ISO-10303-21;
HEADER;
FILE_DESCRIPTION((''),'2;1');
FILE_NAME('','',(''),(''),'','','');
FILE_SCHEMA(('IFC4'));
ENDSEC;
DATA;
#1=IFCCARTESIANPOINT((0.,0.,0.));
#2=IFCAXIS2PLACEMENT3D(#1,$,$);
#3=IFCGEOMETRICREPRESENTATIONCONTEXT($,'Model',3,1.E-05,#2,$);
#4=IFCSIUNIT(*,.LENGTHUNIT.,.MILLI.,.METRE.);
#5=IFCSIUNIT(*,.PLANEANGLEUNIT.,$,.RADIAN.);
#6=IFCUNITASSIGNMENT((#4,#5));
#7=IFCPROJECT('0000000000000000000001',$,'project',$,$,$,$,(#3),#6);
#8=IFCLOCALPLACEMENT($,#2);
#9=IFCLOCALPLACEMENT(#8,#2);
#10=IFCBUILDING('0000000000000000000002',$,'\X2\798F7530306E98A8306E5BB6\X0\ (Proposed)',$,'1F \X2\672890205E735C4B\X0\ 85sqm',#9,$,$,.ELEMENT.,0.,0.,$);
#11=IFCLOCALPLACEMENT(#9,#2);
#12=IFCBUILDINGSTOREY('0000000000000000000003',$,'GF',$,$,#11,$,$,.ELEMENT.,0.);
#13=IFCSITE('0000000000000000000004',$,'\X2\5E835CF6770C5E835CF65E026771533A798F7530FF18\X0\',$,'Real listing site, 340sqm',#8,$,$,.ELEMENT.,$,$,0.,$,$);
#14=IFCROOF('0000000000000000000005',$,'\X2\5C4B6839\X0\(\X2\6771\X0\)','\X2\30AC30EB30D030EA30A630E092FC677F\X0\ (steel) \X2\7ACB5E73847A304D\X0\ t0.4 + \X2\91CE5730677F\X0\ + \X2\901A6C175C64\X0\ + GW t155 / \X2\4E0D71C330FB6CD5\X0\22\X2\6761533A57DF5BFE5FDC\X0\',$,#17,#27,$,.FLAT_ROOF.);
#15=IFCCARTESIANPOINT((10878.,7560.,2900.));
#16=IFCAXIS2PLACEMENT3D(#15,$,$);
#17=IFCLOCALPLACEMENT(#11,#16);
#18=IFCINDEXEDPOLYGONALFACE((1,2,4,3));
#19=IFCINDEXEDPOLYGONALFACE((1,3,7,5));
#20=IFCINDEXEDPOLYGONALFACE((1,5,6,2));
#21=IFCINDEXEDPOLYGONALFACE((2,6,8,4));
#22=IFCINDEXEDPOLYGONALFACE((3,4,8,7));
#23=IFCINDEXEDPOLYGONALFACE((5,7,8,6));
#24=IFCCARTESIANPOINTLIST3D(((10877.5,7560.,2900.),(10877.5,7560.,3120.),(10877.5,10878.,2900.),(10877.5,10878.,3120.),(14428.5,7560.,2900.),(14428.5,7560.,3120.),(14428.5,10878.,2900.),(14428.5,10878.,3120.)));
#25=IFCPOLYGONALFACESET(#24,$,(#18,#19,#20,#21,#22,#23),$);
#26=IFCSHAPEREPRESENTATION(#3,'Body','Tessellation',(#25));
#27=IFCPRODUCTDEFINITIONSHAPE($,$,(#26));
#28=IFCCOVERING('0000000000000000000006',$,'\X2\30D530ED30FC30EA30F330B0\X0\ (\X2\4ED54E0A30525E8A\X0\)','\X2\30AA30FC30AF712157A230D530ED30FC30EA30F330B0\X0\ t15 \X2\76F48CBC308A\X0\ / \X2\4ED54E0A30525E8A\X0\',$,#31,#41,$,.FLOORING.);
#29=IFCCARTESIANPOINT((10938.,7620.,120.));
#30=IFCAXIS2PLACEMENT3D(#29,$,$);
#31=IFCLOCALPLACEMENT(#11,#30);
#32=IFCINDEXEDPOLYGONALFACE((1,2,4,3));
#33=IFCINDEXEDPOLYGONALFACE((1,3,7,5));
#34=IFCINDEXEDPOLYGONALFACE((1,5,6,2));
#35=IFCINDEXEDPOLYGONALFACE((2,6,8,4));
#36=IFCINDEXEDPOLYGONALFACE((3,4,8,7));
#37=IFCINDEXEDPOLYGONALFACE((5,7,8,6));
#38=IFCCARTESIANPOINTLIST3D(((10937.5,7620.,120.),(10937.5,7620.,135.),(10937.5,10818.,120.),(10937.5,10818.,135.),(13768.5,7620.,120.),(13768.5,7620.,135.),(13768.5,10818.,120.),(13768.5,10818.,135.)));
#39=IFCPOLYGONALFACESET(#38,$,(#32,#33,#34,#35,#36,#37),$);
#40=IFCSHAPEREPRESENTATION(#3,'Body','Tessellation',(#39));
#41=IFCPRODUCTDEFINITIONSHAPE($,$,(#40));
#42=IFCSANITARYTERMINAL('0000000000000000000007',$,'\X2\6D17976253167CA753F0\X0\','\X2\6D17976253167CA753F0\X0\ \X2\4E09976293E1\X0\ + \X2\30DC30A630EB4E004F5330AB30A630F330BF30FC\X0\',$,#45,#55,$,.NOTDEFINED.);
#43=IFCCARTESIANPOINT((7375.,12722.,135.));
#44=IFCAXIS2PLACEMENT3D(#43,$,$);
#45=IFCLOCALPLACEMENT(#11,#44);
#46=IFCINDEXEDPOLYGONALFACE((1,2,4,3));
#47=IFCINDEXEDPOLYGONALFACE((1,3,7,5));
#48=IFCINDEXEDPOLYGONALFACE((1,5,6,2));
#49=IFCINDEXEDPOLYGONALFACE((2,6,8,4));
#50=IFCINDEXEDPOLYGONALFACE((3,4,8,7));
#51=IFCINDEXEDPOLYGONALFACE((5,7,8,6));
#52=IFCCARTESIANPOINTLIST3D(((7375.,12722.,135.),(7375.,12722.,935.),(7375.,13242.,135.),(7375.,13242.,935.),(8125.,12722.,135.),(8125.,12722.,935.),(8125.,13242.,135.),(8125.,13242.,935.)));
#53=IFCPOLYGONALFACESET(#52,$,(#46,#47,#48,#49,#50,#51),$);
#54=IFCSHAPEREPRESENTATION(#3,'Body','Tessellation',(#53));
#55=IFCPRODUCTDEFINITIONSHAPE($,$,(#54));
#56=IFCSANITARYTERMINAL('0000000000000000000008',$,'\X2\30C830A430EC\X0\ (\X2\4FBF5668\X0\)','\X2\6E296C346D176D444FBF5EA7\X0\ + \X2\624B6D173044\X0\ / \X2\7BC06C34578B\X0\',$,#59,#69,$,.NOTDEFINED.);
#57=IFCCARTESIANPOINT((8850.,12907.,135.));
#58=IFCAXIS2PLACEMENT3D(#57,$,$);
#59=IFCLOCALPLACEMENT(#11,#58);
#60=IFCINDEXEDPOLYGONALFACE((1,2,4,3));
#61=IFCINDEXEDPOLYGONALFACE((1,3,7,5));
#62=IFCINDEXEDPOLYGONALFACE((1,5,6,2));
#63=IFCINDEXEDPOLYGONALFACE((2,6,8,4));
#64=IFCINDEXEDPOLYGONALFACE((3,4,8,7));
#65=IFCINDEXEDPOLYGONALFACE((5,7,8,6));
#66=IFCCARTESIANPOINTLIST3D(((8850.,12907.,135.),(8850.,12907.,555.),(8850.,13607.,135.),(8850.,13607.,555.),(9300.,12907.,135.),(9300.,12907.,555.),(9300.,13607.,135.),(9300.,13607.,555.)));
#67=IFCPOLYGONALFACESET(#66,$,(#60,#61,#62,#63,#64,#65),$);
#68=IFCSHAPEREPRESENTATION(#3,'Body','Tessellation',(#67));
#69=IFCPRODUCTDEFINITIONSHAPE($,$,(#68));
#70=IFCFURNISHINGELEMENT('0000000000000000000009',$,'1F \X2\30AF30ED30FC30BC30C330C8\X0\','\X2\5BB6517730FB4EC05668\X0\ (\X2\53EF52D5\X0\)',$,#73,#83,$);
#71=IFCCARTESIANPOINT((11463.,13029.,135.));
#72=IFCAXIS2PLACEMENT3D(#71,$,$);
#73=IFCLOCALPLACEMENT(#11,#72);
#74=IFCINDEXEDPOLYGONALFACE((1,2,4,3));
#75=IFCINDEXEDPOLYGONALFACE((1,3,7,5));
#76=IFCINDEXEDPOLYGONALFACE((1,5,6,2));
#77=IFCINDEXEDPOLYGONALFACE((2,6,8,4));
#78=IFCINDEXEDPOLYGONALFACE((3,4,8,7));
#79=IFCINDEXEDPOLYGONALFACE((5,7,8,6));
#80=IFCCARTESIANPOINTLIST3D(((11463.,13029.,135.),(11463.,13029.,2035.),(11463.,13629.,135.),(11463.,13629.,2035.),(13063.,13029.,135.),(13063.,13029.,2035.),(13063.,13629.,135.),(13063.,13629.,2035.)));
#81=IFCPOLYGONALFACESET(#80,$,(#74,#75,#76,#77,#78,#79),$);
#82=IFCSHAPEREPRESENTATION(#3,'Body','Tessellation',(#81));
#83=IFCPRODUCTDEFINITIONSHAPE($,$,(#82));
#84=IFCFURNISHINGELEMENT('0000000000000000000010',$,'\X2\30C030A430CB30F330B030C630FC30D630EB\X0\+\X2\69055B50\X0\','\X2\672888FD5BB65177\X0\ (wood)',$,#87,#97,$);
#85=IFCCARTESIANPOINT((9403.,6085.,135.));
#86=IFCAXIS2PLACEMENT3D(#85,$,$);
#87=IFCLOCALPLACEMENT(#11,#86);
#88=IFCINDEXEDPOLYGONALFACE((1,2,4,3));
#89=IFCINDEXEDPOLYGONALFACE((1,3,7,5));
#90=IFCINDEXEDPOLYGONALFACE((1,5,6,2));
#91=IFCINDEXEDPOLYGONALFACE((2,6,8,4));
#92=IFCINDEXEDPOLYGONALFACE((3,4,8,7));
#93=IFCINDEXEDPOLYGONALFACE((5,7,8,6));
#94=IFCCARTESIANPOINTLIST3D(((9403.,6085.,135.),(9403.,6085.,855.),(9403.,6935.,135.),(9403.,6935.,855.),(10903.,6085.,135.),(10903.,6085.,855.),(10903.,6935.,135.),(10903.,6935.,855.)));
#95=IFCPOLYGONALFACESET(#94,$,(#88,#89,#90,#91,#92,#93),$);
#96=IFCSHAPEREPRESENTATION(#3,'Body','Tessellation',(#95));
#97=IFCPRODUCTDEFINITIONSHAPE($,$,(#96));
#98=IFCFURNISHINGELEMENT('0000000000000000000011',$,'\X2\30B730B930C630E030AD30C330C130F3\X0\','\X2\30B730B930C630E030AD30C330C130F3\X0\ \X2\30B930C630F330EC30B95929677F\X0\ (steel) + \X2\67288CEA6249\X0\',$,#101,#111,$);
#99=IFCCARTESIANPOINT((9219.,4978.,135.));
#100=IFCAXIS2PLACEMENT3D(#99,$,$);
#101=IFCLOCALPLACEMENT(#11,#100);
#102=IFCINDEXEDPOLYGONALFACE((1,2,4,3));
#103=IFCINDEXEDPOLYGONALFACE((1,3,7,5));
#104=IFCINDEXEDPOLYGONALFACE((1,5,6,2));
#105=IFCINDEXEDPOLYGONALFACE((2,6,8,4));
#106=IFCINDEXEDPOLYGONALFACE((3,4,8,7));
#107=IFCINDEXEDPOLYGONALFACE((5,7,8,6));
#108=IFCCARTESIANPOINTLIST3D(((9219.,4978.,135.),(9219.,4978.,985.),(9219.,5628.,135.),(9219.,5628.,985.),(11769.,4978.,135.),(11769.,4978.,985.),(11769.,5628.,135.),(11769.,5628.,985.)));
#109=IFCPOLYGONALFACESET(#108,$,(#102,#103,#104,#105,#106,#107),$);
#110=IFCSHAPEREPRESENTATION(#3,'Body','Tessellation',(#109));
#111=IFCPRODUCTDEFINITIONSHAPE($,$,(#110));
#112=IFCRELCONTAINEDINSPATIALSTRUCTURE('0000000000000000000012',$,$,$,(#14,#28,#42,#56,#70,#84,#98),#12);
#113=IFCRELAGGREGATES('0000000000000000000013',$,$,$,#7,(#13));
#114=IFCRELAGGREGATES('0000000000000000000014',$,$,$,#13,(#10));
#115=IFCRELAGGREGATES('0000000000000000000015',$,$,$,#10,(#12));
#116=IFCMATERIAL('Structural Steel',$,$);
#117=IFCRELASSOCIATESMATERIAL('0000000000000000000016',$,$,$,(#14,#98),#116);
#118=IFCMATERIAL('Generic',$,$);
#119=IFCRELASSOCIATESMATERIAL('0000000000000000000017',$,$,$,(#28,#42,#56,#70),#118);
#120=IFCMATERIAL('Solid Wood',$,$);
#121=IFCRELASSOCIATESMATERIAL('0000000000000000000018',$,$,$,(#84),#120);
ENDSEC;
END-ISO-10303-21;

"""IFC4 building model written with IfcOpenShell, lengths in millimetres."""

from ifc_helpers import new_model, si_unit, frame, frame_2d, origin, place, context, project, spatial, rectangle, extrude, material, element, save


model = new_model("IFC4")

# Units and contexts
model_context = context("Model", 3, precision=1e-05, world=origin())
ifc_project = project(units=[si_unit("LENGTHUNIT", "METRE", prefix="MILLI"), si_unit("PLANEANGLEUNIT", "RADIAN")], contexts=[model_context])

# Site, building, storey
site_placement = place(None, origin())
site = spatial("IfcSite", under=ifc_project, at=site_placement, Name="広島県広島市東区福田８", ObjectType="Real listing site, 340sqm", CompositionType="ELEMENT", RefElevation=0.0)
building_placement = place(site_placement, origin())
building = spatial("IfcBuilding", under=site, at=building_placement, Name="福田の風の家 (Proposed)", ObjectType="1F 木造平屋 85sqm", CompositionType="ELEMENT", ElevationOfRefHeight=0.0, ElevationOfTerrain=0.0)
storey_placement = place(building_placement, origin())
storey = spatial("IfcBuildingStorey", under=building, at=storey_placement, Name="GF", CompositionType="ELEMENT", Elevation=0.0)

# Shared definitions
ifc_material_1 = material(Name="Solid Wood")

# Roof
ifc_material_2 = material(Name="Structural Steel")
roof_placement = place(storey_placement, frame((10878.0, 7560.0, 2900.0)))
element("IfcRoof", 1, at=roof_placement, inside=storey, material=ifc_material_2, Name="屋根(東)", Description="ガルバリウム鋼板 (steel) 立平葺き t0.4 + 野地板 + 通気層 + GW t155 / 不燃・法22条区域対応", PredefinedType="FLAT_ROOF", context=model_context, shape_type="SweptSolid", body=[
    extrude(rectangle(XDim=3551.0, YDim=3318.0, at=frame_2d((1775.0, 1659.0))), frame((10878.0, 7560.0, 2900.0)), (0.0, 0.0, 1.0), 220.0),
])

# Covering
ifc_material_3 = material(Name="Generic")
covering_placement = place(storey_placement, frame((10938.0, 7620.0, 120.0)))
element("IfcCovering", 2, at=covering_placement, inside=storey, material=ifc_material_3, Name="フローリング (仕上げ床)", Description="オーク無垢フローリング t15 直貼り / 仕上げ床", PredefinedType="FLOORING", context=model_context, shape_type="SweptSolid", body=[
    extrude(rectangle(XDim=2831.0, YDim=3198.0, at=frame_2d((1415.0, 1599.0))), frame((10938.0, 7620.0, 120.0)), (0.0, 0.0, 1.0), 15.0),
])

# Sanitary terminals
sanitary_terminal_1_placement = place(storey_placement, frame((7375.0, 12722.0, 135.0)))
element("IfcSanitaryTerminal", 3, at=sanitary_terminal_1_placement, inside=storey, material=ifc_material_3, Name="洗面化粧台", Description="洗面化粧台 三面鏡 + ボウル一体カウンター", PredefinedType="NOTDEFINED", context=model_context, shape_type="SweptSolid", body=[
    extrude(rectangle(XDim=750.0, YDim=520.0, at=frame_2d((375.0, 260.0))), frame((7375.0, 12722.0, 135.0)), (0.0, 0.0, 1.0), 800.0),
])
sanitary_terminal_2_placement = place(storey_placement, frame((8850.0, 12907.0, 135.0)))
element("IfcSanitaryTerminal", 4, at=sanitary_terminal_2_placement, inside=storey, material=ifc_material_3, Name="トイレ (便器)", Description="温水洗浄便座 + 手洗い / 節水型", PredefinedType="NOTDEFINED", context=model_context, shape_type="SweptSolid", body=[
    extrude(rectangle(XDim=450.0, YDim=700.0, at=frame_2d((225.0, 350.0))), frame((8850.0, 12907.0, 135.0)), (0.0, 0.0, 1.0), 420.0),
])

# Furnishing elements
furnishing_1_placement = place(storey_placement, frame((11463.0, 13029.0, 135.0)))
element("IfcFurnishingElement", 5, at=furnishing_1_placement, inside=storey, material=ifc_material_3, Name="1F クローゼット", Description="家具・什器 (可動)", context=model_context, shape_type="SweptSolid", body=[
    extrude(rectangle(XDim=1600.0, YDim=600.0, at=frame_2d((800.0, 300.0))), frame((11463.0, 13029.0, 135.0)), (0.0, 0.0, 1.0), 1900.0),
])
furnishing_2_placement = place(storey_placement, frame((9403.0, 6085.0, 135.0)))
element("IfcFurnishingElement", 6, at=furnishing_2_placement, inside=storey, material=ifc_material_1, Name="ダイニングテーブル+椅子", Description="木製家具 (wood)", context=model_context, shape_type="SweptSolid", body=[
    extrude(rectangle(XDim=1500.0, YDim=850.0, at=frame_2d((750.0, 425.0))), frame((9403.0, 6085.0, 135.0)), (0.0, 0.0, 1.0), 720.0),
])
furnishing_3_placement = place(storey_placement, frame((9219.0, 4978.0, 135.0)))
element("IfcFurnishingElement", 7, at=furnishing_3_placement, inside=storey, material=ifc_material_2, Name="システムキッチン", Description="システムキッチン ステンレス天板 (steel) + 木質扉", context=model_context, shape_type="SweptSolid", body=[
    extrude(rectangle(XDim=2550.0, YDim=650.0, at=frame_2d((1275.0, 325.0))), frame((9219.0, 4978.0, 135.0)), (0.0, 0.0, 1.0), 850.0),
])

save(model, "model.ifc")
